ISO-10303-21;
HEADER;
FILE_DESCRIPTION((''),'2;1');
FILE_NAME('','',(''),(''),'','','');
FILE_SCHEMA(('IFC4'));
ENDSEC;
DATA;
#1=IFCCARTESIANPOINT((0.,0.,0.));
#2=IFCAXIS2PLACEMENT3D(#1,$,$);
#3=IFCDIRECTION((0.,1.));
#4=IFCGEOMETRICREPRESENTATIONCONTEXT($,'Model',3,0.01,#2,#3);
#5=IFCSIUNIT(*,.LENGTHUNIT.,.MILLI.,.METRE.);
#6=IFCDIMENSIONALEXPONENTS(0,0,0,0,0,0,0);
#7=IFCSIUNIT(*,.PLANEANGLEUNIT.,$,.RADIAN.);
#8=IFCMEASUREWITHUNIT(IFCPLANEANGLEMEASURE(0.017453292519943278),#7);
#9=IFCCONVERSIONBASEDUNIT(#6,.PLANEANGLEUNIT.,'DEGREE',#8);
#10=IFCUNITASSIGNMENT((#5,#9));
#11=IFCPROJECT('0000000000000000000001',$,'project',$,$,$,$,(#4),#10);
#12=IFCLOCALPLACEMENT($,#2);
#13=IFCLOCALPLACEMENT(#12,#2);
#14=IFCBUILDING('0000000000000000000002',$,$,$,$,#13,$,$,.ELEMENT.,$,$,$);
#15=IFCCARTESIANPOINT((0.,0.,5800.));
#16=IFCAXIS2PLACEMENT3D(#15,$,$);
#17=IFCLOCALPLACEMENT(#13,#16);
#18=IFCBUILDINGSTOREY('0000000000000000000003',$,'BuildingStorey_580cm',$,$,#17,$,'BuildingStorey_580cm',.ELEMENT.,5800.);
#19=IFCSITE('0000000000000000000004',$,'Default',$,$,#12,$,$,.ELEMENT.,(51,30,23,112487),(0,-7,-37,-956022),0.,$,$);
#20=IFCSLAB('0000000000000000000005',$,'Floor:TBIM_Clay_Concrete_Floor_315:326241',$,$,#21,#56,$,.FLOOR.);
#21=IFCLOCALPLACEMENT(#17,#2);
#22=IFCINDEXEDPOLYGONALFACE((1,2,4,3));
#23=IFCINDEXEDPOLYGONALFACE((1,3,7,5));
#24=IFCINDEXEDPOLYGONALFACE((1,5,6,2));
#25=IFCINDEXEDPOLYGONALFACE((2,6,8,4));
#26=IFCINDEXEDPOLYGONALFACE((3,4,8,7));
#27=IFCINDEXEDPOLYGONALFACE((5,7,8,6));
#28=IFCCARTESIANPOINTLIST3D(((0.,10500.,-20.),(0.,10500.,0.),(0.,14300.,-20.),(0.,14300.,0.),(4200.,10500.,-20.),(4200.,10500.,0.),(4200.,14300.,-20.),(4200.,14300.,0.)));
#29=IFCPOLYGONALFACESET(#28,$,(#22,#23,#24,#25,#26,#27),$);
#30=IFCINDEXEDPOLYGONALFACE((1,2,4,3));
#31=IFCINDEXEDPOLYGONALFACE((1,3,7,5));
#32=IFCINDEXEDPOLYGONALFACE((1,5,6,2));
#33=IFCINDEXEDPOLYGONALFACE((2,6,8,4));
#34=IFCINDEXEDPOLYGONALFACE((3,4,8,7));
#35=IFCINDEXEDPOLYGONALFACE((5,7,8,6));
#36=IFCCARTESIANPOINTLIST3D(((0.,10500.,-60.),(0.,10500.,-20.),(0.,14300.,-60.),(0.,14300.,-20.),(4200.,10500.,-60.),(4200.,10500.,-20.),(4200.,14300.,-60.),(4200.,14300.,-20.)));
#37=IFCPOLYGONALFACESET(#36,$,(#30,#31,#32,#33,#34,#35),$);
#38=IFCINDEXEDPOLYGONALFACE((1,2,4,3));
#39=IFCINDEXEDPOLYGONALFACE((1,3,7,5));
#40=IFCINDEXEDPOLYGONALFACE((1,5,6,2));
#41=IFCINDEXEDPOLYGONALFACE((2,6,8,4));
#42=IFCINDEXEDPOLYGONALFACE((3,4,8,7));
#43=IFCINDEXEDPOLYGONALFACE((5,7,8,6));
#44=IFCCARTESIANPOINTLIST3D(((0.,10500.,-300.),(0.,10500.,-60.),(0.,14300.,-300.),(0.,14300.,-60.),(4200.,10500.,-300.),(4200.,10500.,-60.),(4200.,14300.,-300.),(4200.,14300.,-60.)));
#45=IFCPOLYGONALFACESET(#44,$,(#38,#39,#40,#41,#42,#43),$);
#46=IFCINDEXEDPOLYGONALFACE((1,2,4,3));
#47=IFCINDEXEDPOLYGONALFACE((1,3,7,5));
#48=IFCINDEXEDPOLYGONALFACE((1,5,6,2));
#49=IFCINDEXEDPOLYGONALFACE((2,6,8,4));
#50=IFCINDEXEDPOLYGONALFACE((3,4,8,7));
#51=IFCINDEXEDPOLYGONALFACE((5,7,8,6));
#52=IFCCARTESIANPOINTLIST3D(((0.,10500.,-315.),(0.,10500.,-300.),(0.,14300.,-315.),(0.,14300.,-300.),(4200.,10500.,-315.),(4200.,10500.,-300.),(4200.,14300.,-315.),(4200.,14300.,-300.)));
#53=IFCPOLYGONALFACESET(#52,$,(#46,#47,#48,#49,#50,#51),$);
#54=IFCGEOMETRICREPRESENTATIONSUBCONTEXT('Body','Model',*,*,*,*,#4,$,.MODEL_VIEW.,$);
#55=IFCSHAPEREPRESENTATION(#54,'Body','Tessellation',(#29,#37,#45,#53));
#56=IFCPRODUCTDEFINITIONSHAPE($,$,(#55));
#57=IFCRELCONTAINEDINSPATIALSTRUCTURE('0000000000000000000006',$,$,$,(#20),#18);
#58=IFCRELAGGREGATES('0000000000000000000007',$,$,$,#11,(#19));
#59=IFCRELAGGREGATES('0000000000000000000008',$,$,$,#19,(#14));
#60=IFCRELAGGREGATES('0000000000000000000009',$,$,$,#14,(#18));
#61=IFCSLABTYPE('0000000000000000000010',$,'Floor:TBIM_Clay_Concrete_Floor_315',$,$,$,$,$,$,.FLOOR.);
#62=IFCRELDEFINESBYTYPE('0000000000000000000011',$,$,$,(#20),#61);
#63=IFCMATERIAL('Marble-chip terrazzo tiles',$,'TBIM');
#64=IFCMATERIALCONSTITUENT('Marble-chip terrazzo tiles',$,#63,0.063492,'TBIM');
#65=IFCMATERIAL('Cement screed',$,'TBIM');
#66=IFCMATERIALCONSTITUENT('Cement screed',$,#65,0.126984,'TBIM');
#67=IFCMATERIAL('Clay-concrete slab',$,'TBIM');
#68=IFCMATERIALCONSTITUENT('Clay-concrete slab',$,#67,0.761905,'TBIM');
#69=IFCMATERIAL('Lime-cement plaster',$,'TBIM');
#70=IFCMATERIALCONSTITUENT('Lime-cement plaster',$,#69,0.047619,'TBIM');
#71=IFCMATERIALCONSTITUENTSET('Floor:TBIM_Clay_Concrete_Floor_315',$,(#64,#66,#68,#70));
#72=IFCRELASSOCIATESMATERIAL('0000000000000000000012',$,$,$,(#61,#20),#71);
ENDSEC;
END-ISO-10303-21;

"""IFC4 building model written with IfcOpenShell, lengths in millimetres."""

from ifc_helpers import new_model, entity, si_unit, converted_unit, direction, frame, origin, place, context, subcontext, project, spatial, indexed_curve, outline, extrude, material, constituent, constituent_set, type_object, element, save


model = new_model("IFC4")

# Units and contexts
model_context = context("Model", 3, precision=0.01, world=origin(), true_north=direction((0.0, 1.0)))
body_context = subcontext(model_context, "Body", "Model", "MODEL_VIEW")
ifc_project = project(units=[si_unit("LENGTHUNIT", "METRE", prefix="MILLI"), converted_unit("PLANEANGLEUNIT", "DEGREE", entity("IfcPlaneAngleMeasure", 0.017453292519943278), si_unit("PLANEANGLEUNIT", "RADIAN"), dimensions=[0, 0, 0, 0, 0, 0, 0])], contexts=[model_context])

# Site, building, storey
site_placement = place(None, origin())
site = spatial("IfcSite", under=ifc_project, at=site_placement, Name="Default", CompositionType="ELEMENT", RefLatitude=(51, 30, 23, 112487), RefLongitude=(0, -7, -37, -956022), RefElevation=0.0)
building_placement = place(site_placement, origin())
building = spatial("IfcBuilding", under=site, at=building_placement, CompositionType="ELEMENT")
storey_placement = place(building_placement, frame((0.0, 0.0, 5800.0)))
storey = spatial("IfcBuildingStorey", under=building, at=storey_placement, Name="BuildingStorey_580cm", LongName="BuildingStorey_580cm", CompositionType="ELEMENT", Elevation=5800.0)

# Slab
ifc_material_1 = material(Name="Marble-chip terrazzo tiles", Category="TBIM")
ifc_constituent_1 = constituent(ifc_material_1, Name="Marble-chip terrazzo tiles", Category="TBIM", fraction=0.063492)
ifc_material_2 = material(Name="Cement screed", Category="TBIM")
ifc_constituent_2 = constituent(ifc_material_2, Name="Cement screed", Category="TBIM", fraction=0.126984)
ifc_material_3 = material(Name="Clay-concrete slab", Category="TBIM")
ifc_constituent_3 = constituent(ifc_material_3, Name="Clay-concrete slab", Category="TBIM", fraction=0.761905)
ifc_material_4 = material(Name="Lime-cement plaster", Category="TBIM")
ifc_constituent_4 = constituent(ifc_material_4, Name="Lime-cement plaster", Category="TBIM", fraction=0.047619)
ifc_constituent_set_1 = constituent_set(constituents=[ifc_constituent_1, ifc_constituent_2, ifc_constituent_3, ifc_constituent_4], Name="Floor:TBIM_Clay_Concrete_Floor_315")
slab_type = type_object("IfcSlabType", Name="Floor:TBIM_Clay_Concrete_Floor_315", PredefinedType="FLOOR", material=ifc_constituent_set_1)
slab_1_placement = place(storey_placement, origin())
element("IfcSlab", 1, at=slab_1_placement, inside=storey, type_object=slab_type, material=ifc_constituent_set_1, Name="Floor:TBIM_Clay_Concrete_Floor_315:326241", PredefinedType="FLOOR", context=body_context, shape_type="SweptSolid", body=[
    extrude(outline(indexed_curve([(-2100.0, -1900.0), (2100.0, -1900.0), (2100.0, 1900.0), (-2100.0, 1900.0), (-2100.0, -1900.0)], self_intersect=False)), frame((2100.0, 12400.0, -20.0), z_axis=(0.0, 0.0, 1.0), x_axis=(-1.0, 0.0, 0.0)), (0.0, 0.0, 1.0), 20.0),
    extrude(outline(indexed_curve([(-2100.0, -1900.0), (2100.0, -1900.0), (2100.0, 1900.0), (-2100.0, 1900.0), (-2100.0, -1900.0)], self_intersect=False)), frame((2100.0, 12400.0, -60.0), z_axis=(0.0, 0.0, 1.0), x_axis=(-1.0, 0.0, 0.0)), (0.0, 0.0, 1.0), 40.0),
    extrude(outline(indexed_curve([(-2100.0, -1900.0), (2100.0, -1900.0), (2100.0, 1900.0), (-2100.0, 1900.0), (-2100.0, -1900.0)], self_intersect=False)), frame((2100.0, 12400.0, -300.0), z_axis=(0.0, 0.0, 1.0), x_axis=(-1.0, 0.0, 0.0)), (0.0, 0.0, 1.0), 240.0),
    extrude(outline(indexed_curve([(-2100.0, -1900.0), (2100.0, -1900.0), (2100.0, 1900.0), (-2100.0, 1900.0), (-2100.0, -1900.0)], self_intersect=False)), frame((2100.0, 12400.0, -315.0), z_axis=(0.0, 0.0, 1.0), x_axis=(-1.0, 0.0, 0.0)), (0.0, 0.0, 1.0), 15.0),
])

save(model, "model.ifc")
